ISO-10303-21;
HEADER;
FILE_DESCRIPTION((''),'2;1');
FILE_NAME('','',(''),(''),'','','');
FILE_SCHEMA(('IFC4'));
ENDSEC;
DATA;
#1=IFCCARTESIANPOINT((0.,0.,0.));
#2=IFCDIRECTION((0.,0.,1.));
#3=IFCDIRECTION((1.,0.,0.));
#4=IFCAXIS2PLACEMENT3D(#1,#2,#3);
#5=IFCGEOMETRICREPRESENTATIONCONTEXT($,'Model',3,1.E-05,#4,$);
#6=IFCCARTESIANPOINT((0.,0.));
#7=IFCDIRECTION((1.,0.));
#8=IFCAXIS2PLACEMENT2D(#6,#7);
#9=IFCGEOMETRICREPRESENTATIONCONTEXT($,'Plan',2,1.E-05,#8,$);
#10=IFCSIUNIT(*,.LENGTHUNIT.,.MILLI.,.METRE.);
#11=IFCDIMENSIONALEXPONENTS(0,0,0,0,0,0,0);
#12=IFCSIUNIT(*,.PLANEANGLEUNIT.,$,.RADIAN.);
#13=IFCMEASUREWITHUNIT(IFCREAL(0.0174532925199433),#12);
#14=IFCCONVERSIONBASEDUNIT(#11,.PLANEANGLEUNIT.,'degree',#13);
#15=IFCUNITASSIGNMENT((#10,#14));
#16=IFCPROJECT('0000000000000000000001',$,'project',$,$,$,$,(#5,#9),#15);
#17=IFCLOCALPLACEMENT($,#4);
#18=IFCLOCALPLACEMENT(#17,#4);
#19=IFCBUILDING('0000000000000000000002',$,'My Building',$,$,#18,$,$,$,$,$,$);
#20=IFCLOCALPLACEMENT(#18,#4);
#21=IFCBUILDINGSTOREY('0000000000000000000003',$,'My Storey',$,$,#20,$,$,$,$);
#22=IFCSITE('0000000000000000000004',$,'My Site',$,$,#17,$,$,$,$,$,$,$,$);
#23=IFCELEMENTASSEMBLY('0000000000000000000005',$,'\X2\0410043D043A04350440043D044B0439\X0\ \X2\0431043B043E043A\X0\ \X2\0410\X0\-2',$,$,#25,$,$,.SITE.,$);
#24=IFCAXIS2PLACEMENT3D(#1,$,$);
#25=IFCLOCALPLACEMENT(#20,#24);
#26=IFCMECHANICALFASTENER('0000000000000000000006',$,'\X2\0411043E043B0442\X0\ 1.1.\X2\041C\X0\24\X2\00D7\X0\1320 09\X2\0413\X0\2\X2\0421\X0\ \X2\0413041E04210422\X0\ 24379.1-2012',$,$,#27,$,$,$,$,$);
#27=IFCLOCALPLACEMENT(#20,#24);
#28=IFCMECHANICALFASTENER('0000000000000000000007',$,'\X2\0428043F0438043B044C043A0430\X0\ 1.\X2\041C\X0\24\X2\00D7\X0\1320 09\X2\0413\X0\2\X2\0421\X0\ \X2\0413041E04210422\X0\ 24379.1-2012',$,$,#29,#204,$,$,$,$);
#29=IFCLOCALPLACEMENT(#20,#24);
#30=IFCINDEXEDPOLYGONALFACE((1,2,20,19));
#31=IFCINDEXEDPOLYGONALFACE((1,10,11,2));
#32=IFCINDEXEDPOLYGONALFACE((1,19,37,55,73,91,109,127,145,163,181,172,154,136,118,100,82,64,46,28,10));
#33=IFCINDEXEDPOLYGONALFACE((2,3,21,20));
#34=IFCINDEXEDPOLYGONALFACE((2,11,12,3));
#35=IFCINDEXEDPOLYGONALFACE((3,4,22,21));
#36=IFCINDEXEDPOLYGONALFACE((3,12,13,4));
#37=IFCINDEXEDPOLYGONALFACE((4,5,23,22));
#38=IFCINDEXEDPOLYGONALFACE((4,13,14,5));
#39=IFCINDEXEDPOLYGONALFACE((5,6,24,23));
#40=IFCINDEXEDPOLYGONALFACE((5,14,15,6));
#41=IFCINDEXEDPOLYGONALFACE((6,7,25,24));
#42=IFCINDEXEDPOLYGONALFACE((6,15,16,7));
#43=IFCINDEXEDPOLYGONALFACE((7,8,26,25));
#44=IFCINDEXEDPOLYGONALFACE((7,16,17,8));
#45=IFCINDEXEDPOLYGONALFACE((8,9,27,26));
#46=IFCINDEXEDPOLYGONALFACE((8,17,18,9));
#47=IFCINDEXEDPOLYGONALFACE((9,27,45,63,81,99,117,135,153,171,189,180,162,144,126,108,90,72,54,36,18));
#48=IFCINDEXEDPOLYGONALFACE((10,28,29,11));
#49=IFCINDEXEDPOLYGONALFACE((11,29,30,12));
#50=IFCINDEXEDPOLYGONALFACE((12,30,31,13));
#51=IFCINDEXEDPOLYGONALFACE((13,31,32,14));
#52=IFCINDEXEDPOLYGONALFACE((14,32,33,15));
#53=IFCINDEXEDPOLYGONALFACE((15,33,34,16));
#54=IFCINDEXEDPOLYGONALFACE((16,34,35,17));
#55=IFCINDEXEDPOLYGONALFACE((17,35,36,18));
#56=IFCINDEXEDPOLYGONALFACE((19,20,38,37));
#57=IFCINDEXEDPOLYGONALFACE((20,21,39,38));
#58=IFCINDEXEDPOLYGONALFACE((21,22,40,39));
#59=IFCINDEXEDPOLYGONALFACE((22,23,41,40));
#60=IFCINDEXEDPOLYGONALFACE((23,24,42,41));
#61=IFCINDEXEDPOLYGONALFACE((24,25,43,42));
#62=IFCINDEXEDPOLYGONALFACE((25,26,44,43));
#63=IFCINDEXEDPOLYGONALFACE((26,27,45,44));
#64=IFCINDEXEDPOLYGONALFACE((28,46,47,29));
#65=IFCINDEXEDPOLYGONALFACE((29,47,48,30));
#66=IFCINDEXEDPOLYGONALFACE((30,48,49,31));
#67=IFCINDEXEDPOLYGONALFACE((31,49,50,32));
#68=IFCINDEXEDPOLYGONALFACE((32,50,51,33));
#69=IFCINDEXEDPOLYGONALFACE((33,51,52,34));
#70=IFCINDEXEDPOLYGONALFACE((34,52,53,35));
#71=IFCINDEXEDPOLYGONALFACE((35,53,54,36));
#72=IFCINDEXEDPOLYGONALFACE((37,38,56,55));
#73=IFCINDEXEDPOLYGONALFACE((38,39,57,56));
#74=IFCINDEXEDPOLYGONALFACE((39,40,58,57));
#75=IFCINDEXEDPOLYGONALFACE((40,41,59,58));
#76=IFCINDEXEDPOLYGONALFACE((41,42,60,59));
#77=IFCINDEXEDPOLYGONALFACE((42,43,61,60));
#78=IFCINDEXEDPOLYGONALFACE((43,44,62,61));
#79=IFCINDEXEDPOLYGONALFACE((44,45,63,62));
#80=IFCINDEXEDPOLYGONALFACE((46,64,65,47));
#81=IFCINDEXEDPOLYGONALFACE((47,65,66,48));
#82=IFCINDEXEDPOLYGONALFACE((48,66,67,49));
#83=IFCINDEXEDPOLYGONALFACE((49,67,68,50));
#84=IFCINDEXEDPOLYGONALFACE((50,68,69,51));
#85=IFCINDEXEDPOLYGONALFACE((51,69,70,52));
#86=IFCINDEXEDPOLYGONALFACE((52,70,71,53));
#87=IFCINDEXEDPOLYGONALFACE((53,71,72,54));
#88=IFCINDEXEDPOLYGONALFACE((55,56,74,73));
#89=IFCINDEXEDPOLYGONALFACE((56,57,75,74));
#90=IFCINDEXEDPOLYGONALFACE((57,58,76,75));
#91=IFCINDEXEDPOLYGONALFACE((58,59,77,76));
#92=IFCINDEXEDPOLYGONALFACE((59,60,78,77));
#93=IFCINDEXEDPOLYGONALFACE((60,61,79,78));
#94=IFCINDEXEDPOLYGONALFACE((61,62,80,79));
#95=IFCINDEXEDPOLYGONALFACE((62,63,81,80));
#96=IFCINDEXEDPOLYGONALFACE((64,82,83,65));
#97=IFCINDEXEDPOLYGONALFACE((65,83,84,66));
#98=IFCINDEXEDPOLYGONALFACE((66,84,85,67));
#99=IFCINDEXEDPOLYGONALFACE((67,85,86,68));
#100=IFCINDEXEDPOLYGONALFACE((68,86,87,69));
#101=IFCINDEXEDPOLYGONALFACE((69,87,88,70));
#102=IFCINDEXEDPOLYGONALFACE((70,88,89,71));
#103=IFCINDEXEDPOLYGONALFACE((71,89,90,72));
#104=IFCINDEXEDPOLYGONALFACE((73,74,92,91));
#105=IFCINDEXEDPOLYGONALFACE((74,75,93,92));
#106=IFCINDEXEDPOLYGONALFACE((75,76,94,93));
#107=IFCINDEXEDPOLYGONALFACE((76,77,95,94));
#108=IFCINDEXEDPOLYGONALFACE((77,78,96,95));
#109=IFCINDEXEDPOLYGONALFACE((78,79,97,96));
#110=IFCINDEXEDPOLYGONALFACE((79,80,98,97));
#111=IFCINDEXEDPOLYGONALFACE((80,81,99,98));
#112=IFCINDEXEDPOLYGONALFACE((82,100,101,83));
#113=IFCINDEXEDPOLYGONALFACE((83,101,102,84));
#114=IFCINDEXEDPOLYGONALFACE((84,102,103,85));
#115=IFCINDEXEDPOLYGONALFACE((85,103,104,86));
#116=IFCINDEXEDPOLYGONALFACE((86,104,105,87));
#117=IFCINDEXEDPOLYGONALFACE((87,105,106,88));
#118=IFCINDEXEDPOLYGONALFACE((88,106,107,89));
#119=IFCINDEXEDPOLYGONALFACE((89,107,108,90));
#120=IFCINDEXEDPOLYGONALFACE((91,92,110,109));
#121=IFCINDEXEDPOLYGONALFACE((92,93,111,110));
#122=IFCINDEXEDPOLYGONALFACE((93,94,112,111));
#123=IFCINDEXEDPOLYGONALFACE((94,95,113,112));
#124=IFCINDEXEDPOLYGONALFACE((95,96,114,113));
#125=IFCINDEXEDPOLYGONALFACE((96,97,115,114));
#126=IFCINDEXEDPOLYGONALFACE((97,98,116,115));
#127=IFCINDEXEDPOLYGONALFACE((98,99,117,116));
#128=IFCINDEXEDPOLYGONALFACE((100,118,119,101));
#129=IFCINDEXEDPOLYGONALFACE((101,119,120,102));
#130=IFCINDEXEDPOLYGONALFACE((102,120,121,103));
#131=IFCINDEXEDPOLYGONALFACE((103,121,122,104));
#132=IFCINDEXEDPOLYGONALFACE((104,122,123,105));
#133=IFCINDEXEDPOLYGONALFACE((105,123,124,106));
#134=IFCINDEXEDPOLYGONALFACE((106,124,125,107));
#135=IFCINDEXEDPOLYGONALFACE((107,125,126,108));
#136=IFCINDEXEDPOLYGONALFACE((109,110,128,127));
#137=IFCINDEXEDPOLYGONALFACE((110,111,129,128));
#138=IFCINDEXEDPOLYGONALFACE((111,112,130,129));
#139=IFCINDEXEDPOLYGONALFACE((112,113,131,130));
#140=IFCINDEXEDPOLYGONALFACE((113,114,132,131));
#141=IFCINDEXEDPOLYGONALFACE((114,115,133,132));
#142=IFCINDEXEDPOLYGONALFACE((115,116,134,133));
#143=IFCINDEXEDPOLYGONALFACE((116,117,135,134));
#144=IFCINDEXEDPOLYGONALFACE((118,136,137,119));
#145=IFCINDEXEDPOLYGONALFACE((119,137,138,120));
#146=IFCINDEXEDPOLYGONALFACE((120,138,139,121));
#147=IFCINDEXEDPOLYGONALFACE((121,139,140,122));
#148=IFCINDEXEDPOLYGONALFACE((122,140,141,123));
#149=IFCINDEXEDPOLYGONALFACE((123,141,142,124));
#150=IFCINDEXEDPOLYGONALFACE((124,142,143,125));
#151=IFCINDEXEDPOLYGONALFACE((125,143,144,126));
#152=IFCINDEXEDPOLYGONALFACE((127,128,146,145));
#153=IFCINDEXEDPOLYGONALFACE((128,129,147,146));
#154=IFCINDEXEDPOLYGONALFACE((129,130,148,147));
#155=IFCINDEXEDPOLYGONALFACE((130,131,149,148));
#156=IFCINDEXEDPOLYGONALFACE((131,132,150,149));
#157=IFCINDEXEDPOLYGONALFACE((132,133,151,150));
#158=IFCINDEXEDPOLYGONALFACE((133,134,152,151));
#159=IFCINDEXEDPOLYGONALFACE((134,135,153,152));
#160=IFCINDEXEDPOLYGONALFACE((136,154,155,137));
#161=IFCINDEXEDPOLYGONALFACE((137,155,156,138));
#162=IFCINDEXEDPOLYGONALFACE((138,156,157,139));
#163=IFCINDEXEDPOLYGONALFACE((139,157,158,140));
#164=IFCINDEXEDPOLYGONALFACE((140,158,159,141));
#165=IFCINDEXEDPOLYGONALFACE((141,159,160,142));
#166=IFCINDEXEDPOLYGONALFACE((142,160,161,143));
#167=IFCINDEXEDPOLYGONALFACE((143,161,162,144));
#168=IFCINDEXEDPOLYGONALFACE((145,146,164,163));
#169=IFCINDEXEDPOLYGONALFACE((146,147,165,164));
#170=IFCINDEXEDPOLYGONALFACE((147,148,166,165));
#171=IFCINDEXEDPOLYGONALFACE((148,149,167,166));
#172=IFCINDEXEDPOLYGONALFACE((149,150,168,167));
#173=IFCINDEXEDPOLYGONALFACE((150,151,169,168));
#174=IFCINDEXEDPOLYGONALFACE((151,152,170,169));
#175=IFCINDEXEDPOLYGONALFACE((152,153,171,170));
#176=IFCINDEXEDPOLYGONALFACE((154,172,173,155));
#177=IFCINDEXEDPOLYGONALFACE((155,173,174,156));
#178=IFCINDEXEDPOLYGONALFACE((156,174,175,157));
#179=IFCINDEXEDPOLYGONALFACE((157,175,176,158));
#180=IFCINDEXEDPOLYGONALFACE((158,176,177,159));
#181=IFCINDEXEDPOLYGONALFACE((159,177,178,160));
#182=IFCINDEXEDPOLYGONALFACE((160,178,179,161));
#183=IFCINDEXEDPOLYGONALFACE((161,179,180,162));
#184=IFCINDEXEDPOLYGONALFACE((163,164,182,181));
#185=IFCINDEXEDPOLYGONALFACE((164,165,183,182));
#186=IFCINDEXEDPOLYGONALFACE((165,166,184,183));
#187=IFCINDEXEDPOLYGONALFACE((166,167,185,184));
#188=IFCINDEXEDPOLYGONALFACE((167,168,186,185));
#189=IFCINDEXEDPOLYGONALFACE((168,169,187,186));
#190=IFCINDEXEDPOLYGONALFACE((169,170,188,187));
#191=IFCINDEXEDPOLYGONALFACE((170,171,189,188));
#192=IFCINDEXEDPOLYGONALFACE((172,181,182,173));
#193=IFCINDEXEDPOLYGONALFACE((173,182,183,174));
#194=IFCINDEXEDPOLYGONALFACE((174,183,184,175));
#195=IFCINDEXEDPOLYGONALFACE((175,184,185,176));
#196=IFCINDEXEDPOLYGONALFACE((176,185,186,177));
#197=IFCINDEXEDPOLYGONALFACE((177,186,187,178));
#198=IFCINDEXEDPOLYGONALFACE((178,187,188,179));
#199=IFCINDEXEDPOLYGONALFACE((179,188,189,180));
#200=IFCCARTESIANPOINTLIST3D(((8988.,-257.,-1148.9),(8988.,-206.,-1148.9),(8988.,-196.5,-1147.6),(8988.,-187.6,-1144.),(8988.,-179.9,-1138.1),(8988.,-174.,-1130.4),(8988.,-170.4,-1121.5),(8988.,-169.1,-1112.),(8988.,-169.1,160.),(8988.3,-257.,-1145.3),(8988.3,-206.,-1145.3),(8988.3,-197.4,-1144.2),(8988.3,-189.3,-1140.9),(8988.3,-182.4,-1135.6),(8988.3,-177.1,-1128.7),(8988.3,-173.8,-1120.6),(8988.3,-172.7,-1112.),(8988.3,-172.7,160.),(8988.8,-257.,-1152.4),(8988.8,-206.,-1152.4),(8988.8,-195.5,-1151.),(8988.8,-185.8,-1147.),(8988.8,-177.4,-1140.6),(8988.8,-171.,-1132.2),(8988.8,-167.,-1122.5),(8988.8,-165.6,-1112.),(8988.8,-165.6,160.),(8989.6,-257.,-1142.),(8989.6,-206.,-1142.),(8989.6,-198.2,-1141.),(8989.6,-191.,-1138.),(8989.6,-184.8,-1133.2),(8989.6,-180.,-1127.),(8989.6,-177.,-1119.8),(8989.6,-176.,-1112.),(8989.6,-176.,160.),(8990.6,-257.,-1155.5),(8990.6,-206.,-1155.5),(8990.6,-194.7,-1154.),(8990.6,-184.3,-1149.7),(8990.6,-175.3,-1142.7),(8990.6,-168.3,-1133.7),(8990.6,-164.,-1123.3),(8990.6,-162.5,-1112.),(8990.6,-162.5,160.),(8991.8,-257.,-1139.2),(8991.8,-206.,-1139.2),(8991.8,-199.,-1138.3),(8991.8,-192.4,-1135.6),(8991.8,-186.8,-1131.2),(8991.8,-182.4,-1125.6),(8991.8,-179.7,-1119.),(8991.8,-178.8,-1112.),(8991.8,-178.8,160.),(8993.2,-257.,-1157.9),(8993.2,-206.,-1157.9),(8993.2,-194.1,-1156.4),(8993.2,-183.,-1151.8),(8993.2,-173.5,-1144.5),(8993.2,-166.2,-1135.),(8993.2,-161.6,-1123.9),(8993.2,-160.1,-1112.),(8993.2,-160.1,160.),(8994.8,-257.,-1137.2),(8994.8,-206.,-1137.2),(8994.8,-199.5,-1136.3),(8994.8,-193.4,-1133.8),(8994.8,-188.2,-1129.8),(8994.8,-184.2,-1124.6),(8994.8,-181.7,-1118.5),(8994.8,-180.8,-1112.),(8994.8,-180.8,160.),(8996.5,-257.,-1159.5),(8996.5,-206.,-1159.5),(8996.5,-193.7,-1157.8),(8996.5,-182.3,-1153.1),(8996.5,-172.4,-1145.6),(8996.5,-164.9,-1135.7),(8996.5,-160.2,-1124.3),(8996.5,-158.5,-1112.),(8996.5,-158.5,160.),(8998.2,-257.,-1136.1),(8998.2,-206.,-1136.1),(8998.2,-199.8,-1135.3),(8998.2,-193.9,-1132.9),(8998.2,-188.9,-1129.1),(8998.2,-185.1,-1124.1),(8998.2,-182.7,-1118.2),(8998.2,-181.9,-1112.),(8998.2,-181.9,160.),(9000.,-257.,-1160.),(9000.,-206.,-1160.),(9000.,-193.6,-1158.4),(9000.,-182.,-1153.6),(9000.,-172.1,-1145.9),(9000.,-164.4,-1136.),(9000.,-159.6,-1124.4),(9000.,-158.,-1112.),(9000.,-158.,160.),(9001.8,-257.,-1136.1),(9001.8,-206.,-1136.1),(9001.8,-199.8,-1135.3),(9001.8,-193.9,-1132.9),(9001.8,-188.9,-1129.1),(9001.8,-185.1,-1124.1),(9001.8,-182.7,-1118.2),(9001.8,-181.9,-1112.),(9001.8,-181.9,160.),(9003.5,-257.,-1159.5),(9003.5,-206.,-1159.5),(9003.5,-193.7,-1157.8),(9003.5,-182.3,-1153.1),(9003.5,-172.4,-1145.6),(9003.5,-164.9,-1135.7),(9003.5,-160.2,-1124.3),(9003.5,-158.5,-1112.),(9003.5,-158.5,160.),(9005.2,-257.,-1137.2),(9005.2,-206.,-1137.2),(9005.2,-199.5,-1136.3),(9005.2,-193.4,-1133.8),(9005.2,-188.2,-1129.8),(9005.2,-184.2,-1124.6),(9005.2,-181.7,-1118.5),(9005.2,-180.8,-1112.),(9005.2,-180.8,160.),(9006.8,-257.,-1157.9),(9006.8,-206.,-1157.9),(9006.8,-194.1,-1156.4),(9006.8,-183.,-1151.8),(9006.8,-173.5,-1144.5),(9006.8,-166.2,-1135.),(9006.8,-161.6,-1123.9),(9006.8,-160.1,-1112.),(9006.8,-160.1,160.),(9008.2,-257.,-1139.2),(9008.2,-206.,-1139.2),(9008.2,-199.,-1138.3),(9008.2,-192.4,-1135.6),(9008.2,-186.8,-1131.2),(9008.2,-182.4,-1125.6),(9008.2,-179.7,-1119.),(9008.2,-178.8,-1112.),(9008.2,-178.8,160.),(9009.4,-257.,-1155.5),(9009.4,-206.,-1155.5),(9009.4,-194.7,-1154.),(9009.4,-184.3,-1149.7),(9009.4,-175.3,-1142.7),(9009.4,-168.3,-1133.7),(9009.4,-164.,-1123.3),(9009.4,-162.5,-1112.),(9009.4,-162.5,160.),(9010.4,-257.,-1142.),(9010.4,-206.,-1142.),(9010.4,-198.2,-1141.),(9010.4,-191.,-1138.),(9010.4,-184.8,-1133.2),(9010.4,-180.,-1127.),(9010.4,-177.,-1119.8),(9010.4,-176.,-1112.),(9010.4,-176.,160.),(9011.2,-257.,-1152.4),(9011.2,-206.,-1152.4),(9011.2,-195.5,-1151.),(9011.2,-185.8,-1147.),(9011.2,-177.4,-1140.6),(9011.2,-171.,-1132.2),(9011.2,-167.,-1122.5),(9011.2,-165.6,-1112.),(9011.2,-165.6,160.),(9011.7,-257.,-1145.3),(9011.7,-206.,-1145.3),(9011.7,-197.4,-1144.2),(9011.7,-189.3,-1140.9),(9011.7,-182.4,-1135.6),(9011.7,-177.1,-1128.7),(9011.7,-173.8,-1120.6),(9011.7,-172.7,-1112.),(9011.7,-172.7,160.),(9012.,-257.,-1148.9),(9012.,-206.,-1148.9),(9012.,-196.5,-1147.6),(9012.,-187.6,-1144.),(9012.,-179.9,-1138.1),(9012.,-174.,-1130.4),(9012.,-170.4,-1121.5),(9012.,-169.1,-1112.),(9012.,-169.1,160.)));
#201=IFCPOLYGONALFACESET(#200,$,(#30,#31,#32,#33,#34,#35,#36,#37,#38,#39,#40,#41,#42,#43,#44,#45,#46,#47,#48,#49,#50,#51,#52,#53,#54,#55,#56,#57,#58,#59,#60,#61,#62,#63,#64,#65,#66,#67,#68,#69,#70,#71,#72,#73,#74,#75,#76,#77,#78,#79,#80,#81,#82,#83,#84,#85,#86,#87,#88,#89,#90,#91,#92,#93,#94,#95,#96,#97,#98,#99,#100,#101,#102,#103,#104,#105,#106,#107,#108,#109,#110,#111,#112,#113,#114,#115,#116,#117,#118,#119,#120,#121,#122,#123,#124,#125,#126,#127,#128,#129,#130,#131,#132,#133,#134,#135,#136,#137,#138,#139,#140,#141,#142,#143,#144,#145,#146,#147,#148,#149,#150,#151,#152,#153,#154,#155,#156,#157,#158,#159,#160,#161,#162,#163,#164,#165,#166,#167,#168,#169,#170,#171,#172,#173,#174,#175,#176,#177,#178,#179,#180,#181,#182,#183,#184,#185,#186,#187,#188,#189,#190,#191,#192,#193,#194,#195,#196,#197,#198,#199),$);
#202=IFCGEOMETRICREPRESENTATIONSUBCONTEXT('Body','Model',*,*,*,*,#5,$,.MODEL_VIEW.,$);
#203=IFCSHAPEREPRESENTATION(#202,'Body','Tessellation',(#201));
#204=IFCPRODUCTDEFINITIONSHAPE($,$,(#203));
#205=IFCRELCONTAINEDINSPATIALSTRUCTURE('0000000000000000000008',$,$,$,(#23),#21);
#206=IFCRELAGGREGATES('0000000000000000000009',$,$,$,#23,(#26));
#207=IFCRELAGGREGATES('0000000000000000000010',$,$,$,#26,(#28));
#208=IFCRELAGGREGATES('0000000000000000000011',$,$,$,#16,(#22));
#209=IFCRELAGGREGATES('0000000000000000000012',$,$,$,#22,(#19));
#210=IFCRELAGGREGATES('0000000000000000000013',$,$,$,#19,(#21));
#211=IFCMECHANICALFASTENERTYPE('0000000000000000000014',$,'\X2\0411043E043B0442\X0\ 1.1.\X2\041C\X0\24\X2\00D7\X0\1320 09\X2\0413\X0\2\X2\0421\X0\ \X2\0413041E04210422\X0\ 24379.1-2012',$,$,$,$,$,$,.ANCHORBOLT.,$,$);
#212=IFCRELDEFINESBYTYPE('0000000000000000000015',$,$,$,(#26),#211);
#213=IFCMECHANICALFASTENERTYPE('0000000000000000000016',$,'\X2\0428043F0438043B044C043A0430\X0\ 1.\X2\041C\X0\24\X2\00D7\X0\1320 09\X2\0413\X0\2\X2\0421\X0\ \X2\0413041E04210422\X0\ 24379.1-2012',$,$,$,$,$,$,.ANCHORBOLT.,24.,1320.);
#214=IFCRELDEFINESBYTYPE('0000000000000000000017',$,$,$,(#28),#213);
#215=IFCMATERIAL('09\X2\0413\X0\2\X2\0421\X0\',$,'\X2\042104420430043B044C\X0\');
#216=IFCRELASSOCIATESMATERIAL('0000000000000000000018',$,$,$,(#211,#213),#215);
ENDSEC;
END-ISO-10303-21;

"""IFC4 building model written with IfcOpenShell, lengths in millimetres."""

from ifc_helpers import new_model, entity, si_unit, converted_unit, frame, origin_with_axes, origin_2d_with_axis, place, context, subcontext, project, spatial, source, transform, mapped, material, type_object, type_shapes, element, aggregate, save


model = new_model("IFC4")

# Units and contexts
model_context = context("Model", 3, precision=1e-05, world=origin_with_axes())
plan_context = context("Plan", 2, precision=1e-05, world=origin_2d_with_axis())
body_context = subcontext(model_context, "Body", "Model", "MODEL_VIEW")
ifc_project = project(units=[si_unit("LENGTHUNIT", "METRE", prefix="MILLI"), converted_unit("PLANEANGLEUNIT", "degree", entity("IfcReal", 0.0174532925199433), si_unit("PLANEANGLEUNIT", "RADIAN"), dimensions=[0, 0, 0, 0, 0, 0, 0])], contexts=[model_context, plan_context])

# Site, building, storey
site_placement = place(None, origin_with_axes())
site = spatial("IfcSite", under=ifc_project, at=site_placement, Name="My Site")
building_placement = place(site_placement, origin_with_axes())
building = spatial("IfcBuilding", under=site, at=building_placement, Name="My Building")
storey_placement = place(building_placement, origin_with_axes())
storey = spatial("IfcBuildingStorey", under=building, at=storey_placement, Name="My Storey")

# Element assembly, mechanical fasteners
ifc_material_1 = material(Name="09Г2С", Category="Сталь")
mechanical_fastener_type_1 = type_object("IfcMechanicalFastenerType", Name="Болт 1.1.М24×1320 09Г2С ГОСТ 24379.1-2012", PredefinedType="ANCHORBOLT", material=ifc_material_1)
mechanical_fastener_type_2 = type_object("IfcMechanicalFastenerType", Name="Шпилька 1.М24×1320 09Г2С ГОСТ 24379.1-2012", NominalDiameter=24.0, NominalLength=1320.0, PredefinedType="ANCHORBOLT", material=ifc_material_1)
shared_shape_1 = source(frame((0.0, 0.0, 110.0), z_axis=(0.0, 0.0, 1.0), x_axis=(1.0, 0.0, 0.0)), body_context, "Body", "AdvancedSweptSolid", [
    entity("IfcSweptDiskSolid", entity("IfcIndexedPolyCurve", entity("IfcCartesianPointList3D", [[0.0, 0.0, 0.0], [0.0, 0.0, -1272.0], [10.5, 0.0, -1297.5], [36.0, 0.0, -1308.0], [87.0, 0.0, -1308.0]]), [entity("IfcLineIndex", [1, 2]), entity("IfcArcIndex", [2, 3, 4]), entity("IfcLineIndex", [4, 5])]), 12.0),
])
type_shapes(mechanical_fastener_type_2, [shared_shape_1])
assembly_1_placement = place(storey_placement, frame((9000.0, 0.0, 0.0), z_axis=(0.0, 0.0, 1.0), x_axis=(1.0, 0.0, 0.0)))
assembly_1 = element("IfcElementAssembly", 1, at=assembly_1_placement, inside=storey, Name="Анкерный блок А-2", AssemblyPlace="SITE")
mechanical_fastener_1_placement = place(assembly_1_placement, frame((0.0, -170.0, 0.0), z_axis=(0.0, 0.0, 1.0), x_axis=(1.0, 0.0, 0.0)))
mechanical_fastener_1 = element("IfcMechanicalFastener", 2, at=mechanical_fastener_1_placement, type_object=mechanical_fastener_type_1, Name="Болт 1.1.М24×1320 09Г2С ГОСТ 24379.1-2012")
mechanical_fastener_2_placement = place(mechanical_fastener_1_placement, frame((0.0, 0.0, 50.0), z_axis=(0.0, 0.0, 1.0), x_axis=(0.0, -1.0, 0.0)))
mechanical_fastener_2 = element("IfcMechanicalFastener", 3, at=mechanical_fastener_2_placement, type_object=mechanical_fastener_type_2, Name="Шпилька 1.М24×1320 09Г2С ГОСТ 24379.1-2012", context=body_context, shape_type="MappedRepresentation", body=[
    mapped(shared_shape_1, transform((0.0, 0.0, 0.0), x_axis=(1.0, 0.0, 0.0), y_axis=(0.0, 1.0, 0.0), z_axis=(0.0, 0.0, 1.0), scale=1.0)),
])
aggregate(assembly_1, [mechanical_fastener_1])

aggregate(mechanical_fastener_1, [mechanical_fastener_2])

save(model, "model.ifc")
